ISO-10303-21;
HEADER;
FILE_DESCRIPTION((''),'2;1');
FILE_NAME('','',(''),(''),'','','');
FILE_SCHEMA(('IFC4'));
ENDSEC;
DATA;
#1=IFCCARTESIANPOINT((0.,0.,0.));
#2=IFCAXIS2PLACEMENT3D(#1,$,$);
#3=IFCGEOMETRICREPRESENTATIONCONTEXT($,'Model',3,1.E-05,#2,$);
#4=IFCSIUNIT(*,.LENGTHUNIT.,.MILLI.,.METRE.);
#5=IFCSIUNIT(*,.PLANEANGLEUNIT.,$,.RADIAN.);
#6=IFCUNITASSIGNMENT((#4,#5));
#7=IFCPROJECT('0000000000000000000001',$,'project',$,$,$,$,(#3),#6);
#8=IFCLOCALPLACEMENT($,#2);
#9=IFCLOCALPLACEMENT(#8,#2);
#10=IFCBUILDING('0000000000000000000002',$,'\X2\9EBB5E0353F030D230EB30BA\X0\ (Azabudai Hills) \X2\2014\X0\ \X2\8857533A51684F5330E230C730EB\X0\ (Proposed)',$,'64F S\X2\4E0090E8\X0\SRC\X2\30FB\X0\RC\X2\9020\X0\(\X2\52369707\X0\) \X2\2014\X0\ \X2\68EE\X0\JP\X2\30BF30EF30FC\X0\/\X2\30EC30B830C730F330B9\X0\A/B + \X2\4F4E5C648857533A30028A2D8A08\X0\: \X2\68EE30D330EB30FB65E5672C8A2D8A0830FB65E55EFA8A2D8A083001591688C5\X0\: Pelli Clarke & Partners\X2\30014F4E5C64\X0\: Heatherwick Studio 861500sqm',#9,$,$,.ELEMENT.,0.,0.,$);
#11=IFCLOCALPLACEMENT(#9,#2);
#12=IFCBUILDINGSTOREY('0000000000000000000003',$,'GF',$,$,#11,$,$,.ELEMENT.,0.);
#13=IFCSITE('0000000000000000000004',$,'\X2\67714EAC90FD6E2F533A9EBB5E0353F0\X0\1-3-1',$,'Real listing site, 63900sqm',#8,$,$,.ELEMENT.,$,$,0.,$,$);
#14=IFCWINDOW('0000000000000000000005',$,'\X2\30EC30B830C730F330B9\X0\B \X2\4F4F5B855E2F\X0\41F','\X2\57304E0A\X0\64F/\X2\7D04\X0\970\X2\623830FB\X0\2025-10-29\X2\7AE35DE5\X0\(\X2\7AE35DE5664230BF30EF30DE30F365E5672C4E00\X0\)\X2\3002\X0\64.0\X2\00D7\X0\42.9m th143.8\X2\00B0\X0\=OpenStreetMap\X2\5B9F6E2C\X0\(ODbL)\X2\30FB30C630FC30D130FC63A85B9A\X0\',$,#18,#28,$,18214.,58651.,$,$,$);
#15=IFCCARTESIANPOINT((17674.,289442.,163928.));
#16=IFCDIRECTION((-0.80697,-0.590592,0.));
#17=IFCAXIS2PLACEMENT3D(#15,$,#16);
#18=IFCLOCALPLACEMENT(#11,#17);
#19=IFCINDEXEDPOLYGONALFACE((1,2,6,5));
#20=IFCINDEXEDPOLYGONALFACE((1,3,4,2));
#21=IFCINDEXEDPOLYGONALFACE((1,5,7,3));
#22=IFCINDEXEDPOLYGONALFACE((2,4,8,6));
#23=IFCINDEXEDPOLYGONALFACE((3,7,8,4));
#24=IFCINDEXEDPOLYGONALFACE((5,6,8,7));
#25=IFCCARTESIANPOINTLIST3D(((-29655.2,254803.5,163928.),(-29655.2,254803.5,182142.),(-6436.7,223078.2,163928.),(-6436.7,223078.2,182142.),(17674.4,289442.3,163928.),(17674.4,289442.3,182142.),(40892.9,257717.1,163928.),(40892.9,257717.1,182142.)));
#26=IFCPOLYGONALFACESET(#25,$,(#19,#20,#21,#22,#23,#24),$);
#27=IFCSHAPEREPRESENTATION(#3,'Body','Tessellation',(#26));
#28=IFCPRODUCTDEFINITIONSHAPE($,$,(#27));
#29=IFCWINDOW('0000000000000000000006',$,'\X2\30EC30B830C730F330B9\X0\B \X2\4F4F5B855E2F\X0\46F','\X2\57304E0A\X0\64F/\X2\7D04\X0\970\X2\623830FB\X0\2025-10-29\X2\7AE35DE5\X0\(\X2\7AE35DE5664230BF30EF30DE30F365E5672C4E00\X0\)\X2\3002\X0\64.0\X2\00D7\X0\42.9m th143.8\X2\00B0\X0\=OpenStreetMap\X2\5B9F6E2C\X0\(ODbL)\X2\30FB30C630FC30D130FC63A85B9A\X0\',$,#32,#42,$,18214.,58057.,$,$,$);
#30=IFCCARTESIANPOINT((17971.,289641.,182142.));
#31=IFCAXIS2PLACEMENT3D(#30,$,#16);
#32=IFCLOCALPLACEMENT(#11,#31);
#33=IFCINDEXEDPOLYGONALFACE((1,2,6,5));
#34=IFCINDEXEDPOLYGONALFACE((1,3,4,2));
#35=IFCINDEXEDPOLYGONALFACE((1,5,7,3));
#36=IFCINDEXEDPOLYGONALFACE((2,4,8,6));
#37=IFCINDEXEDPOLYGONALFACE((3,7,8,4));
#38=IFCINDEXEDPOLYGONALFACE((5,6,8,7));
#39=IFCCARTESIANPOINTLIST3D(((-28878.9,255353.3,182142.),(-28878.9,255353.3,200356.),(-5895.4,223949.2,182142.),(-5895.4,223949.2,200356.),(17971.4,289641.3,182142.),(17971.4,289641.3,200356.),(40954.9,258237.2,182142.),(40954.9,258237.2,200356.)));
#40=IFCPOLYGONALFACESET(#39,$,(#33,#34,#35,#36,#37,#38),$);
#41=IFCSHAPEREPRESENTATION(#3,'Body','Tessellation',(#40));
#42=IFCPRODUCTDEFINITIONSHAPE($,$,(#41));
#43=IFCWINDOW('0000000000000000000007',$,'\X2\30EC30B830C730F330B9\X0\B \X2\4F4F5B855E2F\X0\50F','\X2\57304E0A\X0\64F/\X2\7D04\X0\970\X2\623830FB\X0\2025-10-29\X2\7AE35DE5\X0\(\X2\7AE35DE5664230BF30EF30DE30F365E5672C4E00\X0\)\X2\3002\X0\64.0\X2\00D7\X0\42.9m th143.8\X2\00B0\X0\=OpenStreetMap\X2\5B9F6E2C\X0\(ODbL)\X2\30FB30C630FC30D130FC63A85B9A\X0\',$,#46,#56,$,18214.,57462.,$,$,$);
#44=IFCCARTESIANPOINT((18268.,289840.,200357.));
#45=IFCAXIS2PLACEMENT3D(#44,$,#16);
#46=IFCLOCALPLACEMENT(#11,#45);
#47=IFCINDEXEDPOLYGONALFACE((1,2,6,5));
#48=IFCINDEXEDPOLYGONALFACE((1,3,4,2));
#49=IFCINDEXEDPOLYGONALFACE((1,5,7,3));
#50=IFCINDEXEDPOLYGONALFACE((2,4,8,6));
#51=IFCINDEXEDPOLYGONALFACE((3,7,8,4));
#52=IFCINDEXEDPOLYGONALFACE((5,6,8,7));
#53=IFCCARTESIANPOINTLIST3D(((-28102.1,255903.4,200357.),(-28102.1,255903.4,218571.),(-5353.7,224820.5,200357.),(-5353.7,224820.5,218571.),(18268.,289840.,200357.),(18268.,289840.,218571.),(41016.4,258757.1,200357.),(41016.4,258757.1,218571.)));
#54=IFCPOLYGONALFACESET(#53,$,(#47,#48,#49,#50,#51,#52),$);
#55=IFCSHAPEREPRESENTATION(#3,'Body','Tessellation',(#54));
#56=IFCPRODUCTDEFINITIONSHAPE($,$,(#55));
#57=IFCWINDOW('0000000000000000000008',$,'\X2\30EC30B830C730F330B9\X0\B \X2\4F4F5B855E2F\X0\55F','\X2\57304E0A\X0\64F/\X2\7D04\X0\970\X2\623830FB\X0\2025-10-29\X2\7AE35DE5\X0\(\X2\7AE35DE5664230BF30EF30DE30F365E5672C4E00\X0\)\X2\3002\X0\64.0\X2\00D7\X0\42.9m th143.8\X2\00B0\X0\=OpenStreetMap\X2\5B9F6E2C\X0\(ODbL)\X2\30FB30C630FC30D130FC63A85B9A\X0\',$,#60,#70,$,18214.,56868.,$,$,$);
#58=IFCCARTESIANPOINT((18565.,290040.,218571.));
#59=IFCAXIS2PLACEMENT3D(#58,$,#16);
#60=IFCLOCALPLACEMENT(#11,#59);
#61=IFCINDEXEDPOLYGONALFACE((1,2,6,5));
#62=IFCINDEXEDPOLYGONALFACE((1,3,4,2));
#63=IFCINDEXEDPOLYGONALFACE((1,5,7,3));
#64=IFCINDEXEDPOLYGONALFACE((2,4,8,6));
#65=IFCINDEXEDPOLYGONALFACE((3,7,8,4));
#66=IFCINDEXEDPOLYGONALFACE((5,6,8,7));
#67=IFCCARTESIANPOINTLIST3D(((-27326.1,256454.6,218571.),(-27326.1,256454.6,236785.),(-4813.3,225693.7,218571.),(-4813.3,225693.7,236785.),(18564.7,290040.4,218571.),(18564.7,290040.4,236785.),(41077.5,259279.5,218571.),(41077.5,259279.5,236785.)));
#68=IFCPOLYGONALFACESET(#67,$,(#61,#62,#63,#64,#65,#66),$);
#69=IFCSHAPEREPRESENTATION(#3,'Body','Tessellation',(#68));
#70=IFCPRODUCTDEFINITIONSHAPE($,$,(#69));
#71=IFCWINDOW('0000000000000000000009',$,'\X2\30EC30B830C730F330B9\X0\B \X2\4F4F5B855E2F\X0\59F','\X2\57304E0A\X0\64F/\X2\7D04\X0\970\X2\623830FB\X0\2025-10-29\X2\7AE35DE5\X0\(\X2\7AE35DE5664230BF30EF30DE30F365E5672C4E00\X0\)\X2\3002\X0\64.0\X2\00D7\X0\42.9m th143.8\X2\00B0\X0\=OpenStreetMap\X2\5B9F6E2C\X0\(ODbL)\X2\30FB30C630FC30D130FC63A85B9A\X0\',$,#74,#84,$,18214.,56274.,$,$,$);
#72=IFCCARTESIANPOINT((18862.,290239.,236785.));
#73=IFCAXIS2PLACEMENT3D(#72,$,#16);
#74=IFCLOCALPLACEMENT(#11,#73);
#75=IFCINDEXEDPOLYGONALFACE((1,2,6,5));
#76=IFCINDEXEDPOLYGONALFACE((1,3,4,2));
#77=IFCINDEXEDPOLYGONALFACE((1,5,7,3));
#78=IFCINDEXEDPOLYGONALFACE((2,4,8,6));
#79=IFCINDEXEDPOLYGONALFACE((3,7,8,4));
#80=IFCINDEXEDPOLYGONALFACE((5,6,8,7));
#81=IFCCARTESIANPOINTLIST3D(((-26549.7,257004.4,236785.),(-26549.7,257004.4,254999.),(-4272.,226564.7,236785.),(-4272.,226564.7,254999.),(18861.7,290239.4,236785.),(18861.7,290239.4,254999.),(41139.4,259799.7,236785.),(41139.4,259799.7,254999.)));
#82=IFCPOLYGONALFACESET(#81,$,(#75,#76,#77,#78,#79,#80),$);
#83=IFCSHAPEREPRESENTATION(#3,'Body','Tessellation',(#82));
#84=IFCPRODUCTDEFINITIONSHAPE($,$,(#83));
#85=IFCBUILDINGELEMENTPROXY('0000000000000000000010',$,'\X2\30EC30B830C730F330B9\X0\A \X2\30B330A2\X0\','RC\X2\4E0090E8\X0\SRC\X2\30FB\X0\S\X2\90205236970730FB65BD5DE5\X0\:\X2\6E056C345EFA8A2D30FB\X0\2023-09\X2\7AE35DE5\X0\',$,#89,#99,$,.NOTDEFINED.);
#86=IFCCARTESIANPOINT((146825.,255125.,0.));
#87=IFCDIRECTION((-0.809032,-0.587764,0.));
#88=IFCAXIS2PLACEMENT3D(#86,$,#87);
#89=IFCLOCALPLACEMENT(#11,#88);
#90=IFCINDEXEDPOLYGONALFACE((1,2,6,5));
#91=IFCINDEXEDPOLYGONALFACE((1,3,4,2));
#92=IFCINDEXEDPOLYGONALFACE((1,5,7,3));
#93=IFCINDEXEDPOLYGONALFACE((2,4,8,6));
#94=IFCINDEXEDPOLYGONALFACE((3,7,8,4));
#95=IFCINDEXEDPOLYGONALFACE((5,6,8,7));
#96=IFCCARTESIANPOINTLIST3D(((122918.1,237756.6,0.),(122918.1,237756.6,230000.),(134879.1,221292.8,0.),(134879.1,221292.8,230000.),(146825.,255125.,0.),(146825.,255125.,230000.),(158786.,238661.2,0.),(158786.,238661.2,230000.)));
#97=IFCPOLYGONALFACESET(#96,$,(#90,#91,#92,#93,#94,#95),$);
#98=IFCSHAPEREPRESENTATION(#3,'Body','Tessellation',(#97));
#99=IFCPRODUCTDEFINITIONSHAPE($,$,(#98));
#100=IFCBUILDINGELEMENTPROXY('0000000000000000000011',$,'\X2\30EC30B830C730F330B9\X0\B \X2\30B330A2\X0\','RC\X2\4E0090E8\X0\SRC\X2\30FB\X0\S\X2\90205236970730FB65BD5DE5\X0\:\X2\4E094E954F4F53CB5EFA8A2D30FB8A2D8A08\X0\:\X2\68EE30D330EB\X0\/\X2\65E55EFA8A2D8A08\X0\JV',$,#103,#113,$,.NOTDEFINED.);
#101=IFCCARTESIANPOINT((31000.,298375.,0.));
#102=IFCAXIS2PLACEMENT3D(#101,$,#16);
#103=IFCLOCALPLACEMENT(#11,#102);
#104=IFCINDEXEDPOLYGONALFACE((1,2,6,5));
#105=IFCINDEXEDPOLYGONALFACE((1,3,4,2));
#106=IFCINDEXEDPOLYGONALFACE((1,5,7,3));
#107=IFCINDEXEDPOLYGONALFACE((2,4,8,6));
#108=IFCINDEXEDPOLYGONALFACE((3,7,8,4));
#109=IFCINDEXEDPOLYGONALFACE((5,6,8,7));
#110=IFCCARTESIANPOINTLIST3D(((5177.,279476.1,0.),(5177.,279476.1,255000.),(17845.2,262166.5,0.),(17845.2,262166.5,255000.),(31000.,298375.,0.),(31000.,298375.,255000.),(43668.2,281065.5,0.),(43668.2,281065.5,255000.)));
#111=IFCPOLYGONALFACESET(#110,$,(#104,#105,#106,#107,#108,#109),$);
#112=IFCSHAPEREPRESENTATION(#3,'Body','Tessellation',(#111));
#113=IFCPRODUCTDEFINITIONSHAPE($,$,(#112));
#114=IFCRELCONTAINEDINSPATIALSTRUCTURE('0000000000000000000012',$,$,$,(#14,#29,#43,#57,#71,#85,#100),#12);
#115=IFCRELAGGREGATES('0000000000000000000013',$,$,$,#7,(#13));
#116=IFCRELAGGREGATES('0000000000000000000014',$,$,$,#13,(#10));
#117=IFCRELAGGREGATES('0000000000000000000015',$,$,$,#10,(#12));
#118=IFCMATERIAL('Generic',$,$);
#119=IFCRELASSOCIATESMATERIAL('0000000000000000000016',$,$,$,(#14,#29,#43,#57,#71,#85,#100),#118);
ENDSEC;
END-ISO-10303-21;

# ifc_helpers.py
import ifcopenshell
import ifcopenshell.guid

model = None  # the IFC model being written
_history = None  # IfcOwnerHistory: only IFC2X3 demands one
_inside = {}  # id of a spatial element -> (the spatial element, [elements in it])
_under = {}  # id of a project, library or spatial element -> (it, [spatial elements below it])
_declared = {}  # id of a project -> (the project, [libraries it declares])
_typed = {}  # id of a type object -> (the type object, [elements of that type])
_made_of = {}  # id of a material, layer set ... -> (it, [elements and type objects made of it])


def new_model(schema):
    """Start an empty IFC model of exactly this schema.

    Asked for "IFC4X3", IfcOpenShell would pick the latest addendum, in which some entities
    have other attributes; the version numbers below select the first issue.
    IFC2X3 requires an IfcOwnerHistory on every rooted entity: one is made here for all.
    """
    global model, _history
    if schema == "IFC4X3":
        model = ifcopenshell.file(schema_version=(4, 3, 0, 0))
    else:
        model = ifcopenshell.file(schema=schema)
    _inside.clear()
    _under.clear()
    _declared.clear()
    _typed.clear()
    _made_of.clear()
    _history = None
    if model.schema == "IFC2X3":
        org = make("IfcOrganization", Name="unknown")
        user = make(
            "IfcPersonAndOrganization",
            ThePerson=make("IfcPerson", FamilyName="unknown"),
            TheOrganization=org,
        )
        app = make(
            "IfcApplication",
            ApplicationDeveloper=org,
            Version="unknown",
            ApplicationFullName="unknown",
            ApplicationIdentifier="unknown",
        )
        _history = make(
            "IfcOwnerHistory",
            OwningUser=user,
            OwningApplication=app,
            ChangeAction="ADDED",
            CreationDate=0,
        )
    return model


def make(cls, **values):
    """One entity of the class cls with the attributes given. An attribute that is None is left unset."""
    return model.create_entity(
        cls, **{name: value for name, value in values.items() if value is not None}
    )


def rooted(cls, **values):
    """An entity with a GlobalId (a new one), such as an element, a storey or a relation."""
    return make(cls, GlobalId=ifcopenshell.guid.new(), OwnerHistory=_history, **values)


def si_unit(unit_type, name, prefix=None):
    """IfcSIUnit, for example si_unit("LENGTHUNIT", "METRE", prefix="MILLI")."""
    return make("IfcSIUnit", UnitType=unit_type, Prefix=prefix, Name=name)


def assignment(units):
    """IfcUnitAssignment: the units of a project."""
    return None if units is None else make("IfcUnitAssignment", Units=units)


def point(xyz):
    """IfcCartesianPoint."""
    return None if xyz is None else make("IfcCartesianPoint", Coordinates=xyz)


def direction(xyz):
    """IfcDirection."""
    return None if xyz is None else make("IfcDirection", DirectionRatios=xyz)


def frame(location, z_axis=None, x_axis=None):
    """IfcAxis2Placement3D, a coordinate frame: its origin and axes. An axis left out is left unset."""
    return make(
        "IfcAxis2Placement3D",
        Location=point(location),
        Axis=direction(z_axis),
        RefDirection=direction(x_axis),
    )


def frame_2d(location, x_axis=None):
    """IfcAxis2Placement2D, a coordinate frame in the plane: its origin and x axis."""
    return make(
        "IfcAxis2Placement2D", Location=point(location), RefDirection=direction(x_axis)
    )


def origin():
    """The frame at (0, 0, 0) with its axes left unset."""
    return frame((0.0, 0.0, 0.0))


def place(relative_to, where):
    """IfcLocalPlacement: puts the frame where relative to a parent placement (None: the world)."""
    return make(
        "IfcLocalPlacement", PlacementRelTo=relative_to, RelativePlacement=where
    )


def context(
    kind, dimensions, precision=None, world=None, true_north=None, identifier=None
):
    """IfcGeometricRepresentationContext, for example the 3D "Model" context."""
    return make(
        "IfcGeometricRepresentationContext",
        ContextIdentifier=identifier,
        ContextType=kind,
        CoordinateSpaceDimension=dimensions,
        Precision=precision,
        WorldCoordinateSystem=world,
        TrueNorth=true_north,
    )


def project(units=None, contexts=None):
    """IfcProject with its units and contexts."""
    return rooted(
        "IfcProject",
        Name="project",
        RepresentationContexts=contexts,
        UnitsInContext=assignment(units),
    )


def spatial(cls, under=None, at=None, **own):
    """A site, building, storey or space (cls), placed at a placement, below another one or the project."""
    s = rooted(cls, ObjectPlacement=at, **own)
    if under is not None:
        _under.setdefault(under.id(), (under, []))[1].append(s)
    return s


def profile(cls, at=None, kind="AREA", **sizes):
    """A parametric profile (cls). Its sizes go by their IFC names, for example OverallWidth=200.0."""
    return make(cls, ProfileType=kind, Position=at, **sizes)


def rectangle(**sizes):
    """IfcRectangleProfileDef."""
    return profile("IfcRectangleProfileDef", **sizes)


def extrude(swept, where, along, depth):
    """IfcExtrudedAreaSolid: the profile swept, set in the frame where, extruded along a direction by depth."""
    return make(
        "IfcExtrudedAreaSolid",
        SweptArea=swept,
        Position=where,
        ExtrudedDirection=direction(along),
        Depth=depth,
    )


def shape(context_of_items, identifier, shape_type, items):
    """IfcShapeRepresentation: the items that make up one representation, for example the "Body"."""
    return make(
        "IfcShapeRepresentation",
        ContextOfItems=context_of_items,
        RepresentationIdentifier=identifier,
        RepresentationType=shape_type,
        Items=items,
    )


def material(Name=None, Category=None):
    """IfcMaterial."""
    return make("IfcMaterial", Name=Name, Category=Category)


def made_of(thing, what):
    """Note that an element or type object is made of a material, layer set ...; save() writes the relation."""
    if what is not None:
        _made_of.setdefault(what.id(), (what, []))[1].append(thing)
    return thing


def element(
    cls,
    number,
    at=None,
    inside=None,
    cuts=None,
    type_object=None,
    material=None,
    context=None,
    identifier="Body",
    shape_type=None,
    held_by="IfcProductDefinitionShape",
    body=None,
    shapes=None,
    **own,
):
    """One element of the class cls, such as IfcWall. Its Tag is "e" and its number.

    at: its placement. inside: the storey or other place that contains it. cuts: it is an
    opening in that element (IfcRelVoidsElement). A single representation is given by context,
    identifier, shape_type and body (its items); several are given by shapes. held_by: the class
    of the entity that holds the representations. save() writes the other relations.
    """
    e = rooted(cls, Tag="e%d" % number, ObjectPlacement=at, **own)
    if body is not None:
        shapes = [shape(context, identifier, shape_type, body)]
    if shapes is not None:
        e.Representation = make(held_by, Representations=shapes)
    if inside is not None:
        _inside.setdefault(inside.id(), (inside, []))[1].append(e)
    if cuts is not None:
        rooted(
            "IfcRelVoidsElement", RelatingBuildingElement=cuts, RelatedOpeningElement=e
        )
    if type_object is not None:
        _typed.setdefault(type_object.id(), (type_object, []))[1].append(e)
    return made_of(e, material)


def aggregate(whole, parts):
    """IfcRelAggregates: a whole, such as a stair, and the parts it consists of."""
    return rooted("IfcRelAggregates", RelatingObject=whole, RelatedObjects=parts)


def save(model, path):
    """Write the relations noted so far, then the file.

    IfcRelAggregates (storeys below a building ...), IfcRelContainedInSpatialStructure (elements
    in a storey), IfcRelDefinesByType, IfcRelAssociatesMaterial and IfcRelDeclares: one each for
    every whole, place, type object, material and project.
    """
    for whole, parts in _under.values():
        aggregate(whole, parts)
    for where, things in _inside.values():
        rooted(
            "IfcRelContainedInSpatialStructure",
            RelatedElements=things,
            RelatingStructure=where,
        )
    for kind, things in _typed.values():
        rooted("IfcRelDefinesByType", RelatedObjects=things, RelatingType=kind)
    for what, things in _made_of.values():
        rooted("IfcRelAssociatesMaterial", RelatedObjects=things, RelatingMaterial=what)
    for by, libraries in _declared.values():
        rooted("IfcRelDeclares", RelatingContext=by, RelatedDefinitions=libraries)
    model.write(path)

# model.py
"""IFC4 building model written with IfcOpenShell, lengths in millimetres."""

from ifc_helpers import new_model, si_unit, frame, frame_2d, origin, place, context, project, spatial, rectangle, extrude, material, element, save


model = new_model("IFC4")

# Units and contexts
model_context = context("Model", 3, precision=1e-05, world=origin())
ifc_project = project(units=[si_unit("LENGTHUNIT", "METRE", prefix="MILLI"), si_unit("PLANEANGLEUNIT", "RADIAN")], contexts=[model_context])

# Site, building, storey
site_placement = place(None, origin())
site = spatial("IfcSite", under=ifc_project, at=site_placement, Name="東京都港区麻布台1-3-1", ObjectType="Real listing site, 63900sqm", CompositionType="ELEMENT", RefElevation=0.0)
building_placement = place(site_placement, origin())
building = spatial("IfcBuilding", under=site, at=building_placement, Name="麻布台ヒルズ (Azabudai Hills) — 街区全体モデル (Proposed)", ObjectType="64F S一部SRC・RC造(制震) — 森JPタワー/レジデンスA/B + 低層街区。設計: 森ビル・日本設計・日建設計、外装: Pelli Clarke & Partners、低層: Heatherwick Studio 861500sqm", CompositionType="ELEMENT", ElevationOfRefHeight=0.0, ElevationOfTerrain=0.0)
storey_placement = place(building_placement, origin())
storey = spatial("IfcBuildingStorey", under=building, at=storey_placement, Name="GF", CompositionType="ELEMENT", Elevation=0.0)

# Windows
ifc_material = material(Name="Generic")
window_1_placement = place(storey_placement, frame((17674.0, 289442.0, 163928.0), x_axis=(-0.80697, -0.590592, 0.0)))
element("IfcWindow", 1, at=window_1_placement, inside=storey, material=ifc_material, Name="レジデンスB 住宅帯41F", Description="地上64F/約970戸・2025-10-29竣工(竣工時タワマン日本一)。64.0×42.9m th143.8°=OpenStreetMap実測(ODbL)・テーパー推定", OverallHeight=18214.0, OverallWidth=58651.0, context=model_context, shape_type="SweptSolid", body=[
    extrude(rectangle(XDim=58651.0, YDim=39314.0, at=frame_2d((29325.0, 19657.0))), frame((17674.0, 289442.0, 163928.0), x_axis=(-0.80697, -0.590592, 0.0)), (0.0, 0.0, 1.0), 18214.0),
])
window_2_placement = place(storey_placement, frame((17971.0, 289641.0, 182142.0), x_axis=(-0.80697, -0.590592, 0.0)))
element("IfcWindow", 2, at=window_2_placement, inside=storey, material=ifc_material, Name="レジデンスB 住宅帯46F", Description="地上64F/約970戸・2025-10-29竣工(竣工時タワマン日本一)。64.0×42.9m th143.8°=OpenStreetMap実測(ODbL)・テーパー推定", OverallHeight=18214.0, OverallWidth=58057.0, context=model_context, shape_type="SweptSolid", body=[
    extrude(rectangle(XDim=58057.0, YDim=38916.0, at=frame_2d((29028.0, 19458.0))), frame((17971.0, 289641.0, 182142.0), x_axis=(-0.80697, -0.590592, 0.0)), (0.0, 0.0, 1.0), 18214.0),
])
window_3_placement = place(storey_placement, frame((18268.0, 289840.0, 200357.0), x_axis=(-0.80697, -0.590592, 0.0)))
element("IfcWindow", 3, at=window_3_placement, inside=storey, material=ifc_material, Name="レジデンスB 住宅帯50F", Description="地上64F/約970戸・2025-10-29竣工(竣工時タワマン日本一)。64.0×42.9m th143.8°=OpenStreetMap実測(ODbL)・テーパー推定", OverallHeight=18214.0, OverallWidth=57462.0, context=model_context, shape_type="SweptSolid", body=[
    extrude(rectangle(XDim=57462.0, YDim=38518.0, at=frame_2d((28731.0, 19259.0))), frame((18268.0, 289840.0, 200357.0), x_axis=(-0.80697, -0.590592, 0.0)), (0.0, 0.0, 1.0), 18214.0),
])
window_4_placement = place(storey_placement, frame((18565.0, 290040.0, 218571.0), x_axis=(-0.80697, -0.590592, 0.0)))
element("IfcWindow", 4, at=window_4_placement, inside=storey, material=ifc_material, Name="レジデンスB 住宅帯55F", Description="地上64F/約970戸・2025-10-29竣工(竣工時タワマン日本一)。64.0×42.9m th143.8°=OpenStreetMap実測(ODbL)・テーパー推定", OverallHeight=18214.0, OverallWidth=56868.0, context=model_context, shape_type="SweptSolid", body=[
    extrude(rectangle(XDim=56868.0, YDim=38119.0, at=frame_2d((28434.0, 19059.0))), frame((18565.0, 290040.0, 218571.0), x_axis=(-0.80697, -0.590592, 0.0)), (0.0, 0.0, 1.0), 18214.0),
])
window_5_placement = place(storey_placement, frame((18862.0, 290239.0, 236785.0), x_axis=(-0.80697, -0.590592, 0.0)))
element("IfcWindow", 5, at=window_5_placement, inside=storey, material=ifc_material, Name="レジデンスB 住宅帯59F", Description="地上64F/約970戸・2025-10-29竣工(竣工時タワマン日本一)。64.0×42.9m th143.8°=OpenStreetMap実測(ODbL)・テーパー推定", OverallHeight=18214.0, OverallWidth=56274.0, context=model_context, shape_type="SweptSolid", body=[
    extrude(rectangle(XDim=56274.0, YDim=37721.0, at=frame_2d((28137.0, 18860.0))), frame((18862.0, 290239.0, 236785.0), x_axis=(-0.80697, -0.590592, 0.0)), (0.0, 0.0, 1.0), 18214.0),
])

# Building element proxies
proxy_1_placement = place(storey_placement, frame((146825.0, 255125.0, 0.0), x_axis=(-0.809032, -0.587764, 0.0)))
element("IfcBuildingElementProxy", 6, at=proxy_1_placement, inside=storey, material=ifc_material, Name="レジデンスA コア", Description="RC一部SRC・S造制震・施工:清水建設・2023-09竣工", PredefinedType="NOTDEFINED", context=model_context, shape_type="SweptSolid", body=[
    extrude(rectangle(XDim=29550.0, YDim=20350.0, at=frame_2d((14775.0, 10175.0))), frame((146825.0, 255125.0, 0.0), x_axis=(-0.809032, -0.587764, 0.0)), (0.0, 0.0, 1.0), 230000.0),
])
proxy_2_placement = place(storey_placement, frame((31000.0, 298375.0, 0.0), x_axis=(-0.80697, -0.590592, 0.0)))
element("IfcBuildingElementProxy", 7, at=proxy_2_placement, inside=storey, material=ifc_material, Name="レジデンスB コア", Description="RC一部SRC・S造制震・施工:三井住友建設・設計:森ビル/日建設計JV", PredefinedType="NOTDEFINED", context=model_context, shape_type="SweptSolid", body=[
    extrude(rectangle(XDim=32000.0, YDim=21450.0, at=frame_2d((16000.0, 10725.0))), frame((31000.0, 298375.0, 0.0), x_axis=(-0.80697, -0.590592, 0.0)), (0.0, 0.0, 1.0), 255000.0),
])

save(model, "model.ifc")
